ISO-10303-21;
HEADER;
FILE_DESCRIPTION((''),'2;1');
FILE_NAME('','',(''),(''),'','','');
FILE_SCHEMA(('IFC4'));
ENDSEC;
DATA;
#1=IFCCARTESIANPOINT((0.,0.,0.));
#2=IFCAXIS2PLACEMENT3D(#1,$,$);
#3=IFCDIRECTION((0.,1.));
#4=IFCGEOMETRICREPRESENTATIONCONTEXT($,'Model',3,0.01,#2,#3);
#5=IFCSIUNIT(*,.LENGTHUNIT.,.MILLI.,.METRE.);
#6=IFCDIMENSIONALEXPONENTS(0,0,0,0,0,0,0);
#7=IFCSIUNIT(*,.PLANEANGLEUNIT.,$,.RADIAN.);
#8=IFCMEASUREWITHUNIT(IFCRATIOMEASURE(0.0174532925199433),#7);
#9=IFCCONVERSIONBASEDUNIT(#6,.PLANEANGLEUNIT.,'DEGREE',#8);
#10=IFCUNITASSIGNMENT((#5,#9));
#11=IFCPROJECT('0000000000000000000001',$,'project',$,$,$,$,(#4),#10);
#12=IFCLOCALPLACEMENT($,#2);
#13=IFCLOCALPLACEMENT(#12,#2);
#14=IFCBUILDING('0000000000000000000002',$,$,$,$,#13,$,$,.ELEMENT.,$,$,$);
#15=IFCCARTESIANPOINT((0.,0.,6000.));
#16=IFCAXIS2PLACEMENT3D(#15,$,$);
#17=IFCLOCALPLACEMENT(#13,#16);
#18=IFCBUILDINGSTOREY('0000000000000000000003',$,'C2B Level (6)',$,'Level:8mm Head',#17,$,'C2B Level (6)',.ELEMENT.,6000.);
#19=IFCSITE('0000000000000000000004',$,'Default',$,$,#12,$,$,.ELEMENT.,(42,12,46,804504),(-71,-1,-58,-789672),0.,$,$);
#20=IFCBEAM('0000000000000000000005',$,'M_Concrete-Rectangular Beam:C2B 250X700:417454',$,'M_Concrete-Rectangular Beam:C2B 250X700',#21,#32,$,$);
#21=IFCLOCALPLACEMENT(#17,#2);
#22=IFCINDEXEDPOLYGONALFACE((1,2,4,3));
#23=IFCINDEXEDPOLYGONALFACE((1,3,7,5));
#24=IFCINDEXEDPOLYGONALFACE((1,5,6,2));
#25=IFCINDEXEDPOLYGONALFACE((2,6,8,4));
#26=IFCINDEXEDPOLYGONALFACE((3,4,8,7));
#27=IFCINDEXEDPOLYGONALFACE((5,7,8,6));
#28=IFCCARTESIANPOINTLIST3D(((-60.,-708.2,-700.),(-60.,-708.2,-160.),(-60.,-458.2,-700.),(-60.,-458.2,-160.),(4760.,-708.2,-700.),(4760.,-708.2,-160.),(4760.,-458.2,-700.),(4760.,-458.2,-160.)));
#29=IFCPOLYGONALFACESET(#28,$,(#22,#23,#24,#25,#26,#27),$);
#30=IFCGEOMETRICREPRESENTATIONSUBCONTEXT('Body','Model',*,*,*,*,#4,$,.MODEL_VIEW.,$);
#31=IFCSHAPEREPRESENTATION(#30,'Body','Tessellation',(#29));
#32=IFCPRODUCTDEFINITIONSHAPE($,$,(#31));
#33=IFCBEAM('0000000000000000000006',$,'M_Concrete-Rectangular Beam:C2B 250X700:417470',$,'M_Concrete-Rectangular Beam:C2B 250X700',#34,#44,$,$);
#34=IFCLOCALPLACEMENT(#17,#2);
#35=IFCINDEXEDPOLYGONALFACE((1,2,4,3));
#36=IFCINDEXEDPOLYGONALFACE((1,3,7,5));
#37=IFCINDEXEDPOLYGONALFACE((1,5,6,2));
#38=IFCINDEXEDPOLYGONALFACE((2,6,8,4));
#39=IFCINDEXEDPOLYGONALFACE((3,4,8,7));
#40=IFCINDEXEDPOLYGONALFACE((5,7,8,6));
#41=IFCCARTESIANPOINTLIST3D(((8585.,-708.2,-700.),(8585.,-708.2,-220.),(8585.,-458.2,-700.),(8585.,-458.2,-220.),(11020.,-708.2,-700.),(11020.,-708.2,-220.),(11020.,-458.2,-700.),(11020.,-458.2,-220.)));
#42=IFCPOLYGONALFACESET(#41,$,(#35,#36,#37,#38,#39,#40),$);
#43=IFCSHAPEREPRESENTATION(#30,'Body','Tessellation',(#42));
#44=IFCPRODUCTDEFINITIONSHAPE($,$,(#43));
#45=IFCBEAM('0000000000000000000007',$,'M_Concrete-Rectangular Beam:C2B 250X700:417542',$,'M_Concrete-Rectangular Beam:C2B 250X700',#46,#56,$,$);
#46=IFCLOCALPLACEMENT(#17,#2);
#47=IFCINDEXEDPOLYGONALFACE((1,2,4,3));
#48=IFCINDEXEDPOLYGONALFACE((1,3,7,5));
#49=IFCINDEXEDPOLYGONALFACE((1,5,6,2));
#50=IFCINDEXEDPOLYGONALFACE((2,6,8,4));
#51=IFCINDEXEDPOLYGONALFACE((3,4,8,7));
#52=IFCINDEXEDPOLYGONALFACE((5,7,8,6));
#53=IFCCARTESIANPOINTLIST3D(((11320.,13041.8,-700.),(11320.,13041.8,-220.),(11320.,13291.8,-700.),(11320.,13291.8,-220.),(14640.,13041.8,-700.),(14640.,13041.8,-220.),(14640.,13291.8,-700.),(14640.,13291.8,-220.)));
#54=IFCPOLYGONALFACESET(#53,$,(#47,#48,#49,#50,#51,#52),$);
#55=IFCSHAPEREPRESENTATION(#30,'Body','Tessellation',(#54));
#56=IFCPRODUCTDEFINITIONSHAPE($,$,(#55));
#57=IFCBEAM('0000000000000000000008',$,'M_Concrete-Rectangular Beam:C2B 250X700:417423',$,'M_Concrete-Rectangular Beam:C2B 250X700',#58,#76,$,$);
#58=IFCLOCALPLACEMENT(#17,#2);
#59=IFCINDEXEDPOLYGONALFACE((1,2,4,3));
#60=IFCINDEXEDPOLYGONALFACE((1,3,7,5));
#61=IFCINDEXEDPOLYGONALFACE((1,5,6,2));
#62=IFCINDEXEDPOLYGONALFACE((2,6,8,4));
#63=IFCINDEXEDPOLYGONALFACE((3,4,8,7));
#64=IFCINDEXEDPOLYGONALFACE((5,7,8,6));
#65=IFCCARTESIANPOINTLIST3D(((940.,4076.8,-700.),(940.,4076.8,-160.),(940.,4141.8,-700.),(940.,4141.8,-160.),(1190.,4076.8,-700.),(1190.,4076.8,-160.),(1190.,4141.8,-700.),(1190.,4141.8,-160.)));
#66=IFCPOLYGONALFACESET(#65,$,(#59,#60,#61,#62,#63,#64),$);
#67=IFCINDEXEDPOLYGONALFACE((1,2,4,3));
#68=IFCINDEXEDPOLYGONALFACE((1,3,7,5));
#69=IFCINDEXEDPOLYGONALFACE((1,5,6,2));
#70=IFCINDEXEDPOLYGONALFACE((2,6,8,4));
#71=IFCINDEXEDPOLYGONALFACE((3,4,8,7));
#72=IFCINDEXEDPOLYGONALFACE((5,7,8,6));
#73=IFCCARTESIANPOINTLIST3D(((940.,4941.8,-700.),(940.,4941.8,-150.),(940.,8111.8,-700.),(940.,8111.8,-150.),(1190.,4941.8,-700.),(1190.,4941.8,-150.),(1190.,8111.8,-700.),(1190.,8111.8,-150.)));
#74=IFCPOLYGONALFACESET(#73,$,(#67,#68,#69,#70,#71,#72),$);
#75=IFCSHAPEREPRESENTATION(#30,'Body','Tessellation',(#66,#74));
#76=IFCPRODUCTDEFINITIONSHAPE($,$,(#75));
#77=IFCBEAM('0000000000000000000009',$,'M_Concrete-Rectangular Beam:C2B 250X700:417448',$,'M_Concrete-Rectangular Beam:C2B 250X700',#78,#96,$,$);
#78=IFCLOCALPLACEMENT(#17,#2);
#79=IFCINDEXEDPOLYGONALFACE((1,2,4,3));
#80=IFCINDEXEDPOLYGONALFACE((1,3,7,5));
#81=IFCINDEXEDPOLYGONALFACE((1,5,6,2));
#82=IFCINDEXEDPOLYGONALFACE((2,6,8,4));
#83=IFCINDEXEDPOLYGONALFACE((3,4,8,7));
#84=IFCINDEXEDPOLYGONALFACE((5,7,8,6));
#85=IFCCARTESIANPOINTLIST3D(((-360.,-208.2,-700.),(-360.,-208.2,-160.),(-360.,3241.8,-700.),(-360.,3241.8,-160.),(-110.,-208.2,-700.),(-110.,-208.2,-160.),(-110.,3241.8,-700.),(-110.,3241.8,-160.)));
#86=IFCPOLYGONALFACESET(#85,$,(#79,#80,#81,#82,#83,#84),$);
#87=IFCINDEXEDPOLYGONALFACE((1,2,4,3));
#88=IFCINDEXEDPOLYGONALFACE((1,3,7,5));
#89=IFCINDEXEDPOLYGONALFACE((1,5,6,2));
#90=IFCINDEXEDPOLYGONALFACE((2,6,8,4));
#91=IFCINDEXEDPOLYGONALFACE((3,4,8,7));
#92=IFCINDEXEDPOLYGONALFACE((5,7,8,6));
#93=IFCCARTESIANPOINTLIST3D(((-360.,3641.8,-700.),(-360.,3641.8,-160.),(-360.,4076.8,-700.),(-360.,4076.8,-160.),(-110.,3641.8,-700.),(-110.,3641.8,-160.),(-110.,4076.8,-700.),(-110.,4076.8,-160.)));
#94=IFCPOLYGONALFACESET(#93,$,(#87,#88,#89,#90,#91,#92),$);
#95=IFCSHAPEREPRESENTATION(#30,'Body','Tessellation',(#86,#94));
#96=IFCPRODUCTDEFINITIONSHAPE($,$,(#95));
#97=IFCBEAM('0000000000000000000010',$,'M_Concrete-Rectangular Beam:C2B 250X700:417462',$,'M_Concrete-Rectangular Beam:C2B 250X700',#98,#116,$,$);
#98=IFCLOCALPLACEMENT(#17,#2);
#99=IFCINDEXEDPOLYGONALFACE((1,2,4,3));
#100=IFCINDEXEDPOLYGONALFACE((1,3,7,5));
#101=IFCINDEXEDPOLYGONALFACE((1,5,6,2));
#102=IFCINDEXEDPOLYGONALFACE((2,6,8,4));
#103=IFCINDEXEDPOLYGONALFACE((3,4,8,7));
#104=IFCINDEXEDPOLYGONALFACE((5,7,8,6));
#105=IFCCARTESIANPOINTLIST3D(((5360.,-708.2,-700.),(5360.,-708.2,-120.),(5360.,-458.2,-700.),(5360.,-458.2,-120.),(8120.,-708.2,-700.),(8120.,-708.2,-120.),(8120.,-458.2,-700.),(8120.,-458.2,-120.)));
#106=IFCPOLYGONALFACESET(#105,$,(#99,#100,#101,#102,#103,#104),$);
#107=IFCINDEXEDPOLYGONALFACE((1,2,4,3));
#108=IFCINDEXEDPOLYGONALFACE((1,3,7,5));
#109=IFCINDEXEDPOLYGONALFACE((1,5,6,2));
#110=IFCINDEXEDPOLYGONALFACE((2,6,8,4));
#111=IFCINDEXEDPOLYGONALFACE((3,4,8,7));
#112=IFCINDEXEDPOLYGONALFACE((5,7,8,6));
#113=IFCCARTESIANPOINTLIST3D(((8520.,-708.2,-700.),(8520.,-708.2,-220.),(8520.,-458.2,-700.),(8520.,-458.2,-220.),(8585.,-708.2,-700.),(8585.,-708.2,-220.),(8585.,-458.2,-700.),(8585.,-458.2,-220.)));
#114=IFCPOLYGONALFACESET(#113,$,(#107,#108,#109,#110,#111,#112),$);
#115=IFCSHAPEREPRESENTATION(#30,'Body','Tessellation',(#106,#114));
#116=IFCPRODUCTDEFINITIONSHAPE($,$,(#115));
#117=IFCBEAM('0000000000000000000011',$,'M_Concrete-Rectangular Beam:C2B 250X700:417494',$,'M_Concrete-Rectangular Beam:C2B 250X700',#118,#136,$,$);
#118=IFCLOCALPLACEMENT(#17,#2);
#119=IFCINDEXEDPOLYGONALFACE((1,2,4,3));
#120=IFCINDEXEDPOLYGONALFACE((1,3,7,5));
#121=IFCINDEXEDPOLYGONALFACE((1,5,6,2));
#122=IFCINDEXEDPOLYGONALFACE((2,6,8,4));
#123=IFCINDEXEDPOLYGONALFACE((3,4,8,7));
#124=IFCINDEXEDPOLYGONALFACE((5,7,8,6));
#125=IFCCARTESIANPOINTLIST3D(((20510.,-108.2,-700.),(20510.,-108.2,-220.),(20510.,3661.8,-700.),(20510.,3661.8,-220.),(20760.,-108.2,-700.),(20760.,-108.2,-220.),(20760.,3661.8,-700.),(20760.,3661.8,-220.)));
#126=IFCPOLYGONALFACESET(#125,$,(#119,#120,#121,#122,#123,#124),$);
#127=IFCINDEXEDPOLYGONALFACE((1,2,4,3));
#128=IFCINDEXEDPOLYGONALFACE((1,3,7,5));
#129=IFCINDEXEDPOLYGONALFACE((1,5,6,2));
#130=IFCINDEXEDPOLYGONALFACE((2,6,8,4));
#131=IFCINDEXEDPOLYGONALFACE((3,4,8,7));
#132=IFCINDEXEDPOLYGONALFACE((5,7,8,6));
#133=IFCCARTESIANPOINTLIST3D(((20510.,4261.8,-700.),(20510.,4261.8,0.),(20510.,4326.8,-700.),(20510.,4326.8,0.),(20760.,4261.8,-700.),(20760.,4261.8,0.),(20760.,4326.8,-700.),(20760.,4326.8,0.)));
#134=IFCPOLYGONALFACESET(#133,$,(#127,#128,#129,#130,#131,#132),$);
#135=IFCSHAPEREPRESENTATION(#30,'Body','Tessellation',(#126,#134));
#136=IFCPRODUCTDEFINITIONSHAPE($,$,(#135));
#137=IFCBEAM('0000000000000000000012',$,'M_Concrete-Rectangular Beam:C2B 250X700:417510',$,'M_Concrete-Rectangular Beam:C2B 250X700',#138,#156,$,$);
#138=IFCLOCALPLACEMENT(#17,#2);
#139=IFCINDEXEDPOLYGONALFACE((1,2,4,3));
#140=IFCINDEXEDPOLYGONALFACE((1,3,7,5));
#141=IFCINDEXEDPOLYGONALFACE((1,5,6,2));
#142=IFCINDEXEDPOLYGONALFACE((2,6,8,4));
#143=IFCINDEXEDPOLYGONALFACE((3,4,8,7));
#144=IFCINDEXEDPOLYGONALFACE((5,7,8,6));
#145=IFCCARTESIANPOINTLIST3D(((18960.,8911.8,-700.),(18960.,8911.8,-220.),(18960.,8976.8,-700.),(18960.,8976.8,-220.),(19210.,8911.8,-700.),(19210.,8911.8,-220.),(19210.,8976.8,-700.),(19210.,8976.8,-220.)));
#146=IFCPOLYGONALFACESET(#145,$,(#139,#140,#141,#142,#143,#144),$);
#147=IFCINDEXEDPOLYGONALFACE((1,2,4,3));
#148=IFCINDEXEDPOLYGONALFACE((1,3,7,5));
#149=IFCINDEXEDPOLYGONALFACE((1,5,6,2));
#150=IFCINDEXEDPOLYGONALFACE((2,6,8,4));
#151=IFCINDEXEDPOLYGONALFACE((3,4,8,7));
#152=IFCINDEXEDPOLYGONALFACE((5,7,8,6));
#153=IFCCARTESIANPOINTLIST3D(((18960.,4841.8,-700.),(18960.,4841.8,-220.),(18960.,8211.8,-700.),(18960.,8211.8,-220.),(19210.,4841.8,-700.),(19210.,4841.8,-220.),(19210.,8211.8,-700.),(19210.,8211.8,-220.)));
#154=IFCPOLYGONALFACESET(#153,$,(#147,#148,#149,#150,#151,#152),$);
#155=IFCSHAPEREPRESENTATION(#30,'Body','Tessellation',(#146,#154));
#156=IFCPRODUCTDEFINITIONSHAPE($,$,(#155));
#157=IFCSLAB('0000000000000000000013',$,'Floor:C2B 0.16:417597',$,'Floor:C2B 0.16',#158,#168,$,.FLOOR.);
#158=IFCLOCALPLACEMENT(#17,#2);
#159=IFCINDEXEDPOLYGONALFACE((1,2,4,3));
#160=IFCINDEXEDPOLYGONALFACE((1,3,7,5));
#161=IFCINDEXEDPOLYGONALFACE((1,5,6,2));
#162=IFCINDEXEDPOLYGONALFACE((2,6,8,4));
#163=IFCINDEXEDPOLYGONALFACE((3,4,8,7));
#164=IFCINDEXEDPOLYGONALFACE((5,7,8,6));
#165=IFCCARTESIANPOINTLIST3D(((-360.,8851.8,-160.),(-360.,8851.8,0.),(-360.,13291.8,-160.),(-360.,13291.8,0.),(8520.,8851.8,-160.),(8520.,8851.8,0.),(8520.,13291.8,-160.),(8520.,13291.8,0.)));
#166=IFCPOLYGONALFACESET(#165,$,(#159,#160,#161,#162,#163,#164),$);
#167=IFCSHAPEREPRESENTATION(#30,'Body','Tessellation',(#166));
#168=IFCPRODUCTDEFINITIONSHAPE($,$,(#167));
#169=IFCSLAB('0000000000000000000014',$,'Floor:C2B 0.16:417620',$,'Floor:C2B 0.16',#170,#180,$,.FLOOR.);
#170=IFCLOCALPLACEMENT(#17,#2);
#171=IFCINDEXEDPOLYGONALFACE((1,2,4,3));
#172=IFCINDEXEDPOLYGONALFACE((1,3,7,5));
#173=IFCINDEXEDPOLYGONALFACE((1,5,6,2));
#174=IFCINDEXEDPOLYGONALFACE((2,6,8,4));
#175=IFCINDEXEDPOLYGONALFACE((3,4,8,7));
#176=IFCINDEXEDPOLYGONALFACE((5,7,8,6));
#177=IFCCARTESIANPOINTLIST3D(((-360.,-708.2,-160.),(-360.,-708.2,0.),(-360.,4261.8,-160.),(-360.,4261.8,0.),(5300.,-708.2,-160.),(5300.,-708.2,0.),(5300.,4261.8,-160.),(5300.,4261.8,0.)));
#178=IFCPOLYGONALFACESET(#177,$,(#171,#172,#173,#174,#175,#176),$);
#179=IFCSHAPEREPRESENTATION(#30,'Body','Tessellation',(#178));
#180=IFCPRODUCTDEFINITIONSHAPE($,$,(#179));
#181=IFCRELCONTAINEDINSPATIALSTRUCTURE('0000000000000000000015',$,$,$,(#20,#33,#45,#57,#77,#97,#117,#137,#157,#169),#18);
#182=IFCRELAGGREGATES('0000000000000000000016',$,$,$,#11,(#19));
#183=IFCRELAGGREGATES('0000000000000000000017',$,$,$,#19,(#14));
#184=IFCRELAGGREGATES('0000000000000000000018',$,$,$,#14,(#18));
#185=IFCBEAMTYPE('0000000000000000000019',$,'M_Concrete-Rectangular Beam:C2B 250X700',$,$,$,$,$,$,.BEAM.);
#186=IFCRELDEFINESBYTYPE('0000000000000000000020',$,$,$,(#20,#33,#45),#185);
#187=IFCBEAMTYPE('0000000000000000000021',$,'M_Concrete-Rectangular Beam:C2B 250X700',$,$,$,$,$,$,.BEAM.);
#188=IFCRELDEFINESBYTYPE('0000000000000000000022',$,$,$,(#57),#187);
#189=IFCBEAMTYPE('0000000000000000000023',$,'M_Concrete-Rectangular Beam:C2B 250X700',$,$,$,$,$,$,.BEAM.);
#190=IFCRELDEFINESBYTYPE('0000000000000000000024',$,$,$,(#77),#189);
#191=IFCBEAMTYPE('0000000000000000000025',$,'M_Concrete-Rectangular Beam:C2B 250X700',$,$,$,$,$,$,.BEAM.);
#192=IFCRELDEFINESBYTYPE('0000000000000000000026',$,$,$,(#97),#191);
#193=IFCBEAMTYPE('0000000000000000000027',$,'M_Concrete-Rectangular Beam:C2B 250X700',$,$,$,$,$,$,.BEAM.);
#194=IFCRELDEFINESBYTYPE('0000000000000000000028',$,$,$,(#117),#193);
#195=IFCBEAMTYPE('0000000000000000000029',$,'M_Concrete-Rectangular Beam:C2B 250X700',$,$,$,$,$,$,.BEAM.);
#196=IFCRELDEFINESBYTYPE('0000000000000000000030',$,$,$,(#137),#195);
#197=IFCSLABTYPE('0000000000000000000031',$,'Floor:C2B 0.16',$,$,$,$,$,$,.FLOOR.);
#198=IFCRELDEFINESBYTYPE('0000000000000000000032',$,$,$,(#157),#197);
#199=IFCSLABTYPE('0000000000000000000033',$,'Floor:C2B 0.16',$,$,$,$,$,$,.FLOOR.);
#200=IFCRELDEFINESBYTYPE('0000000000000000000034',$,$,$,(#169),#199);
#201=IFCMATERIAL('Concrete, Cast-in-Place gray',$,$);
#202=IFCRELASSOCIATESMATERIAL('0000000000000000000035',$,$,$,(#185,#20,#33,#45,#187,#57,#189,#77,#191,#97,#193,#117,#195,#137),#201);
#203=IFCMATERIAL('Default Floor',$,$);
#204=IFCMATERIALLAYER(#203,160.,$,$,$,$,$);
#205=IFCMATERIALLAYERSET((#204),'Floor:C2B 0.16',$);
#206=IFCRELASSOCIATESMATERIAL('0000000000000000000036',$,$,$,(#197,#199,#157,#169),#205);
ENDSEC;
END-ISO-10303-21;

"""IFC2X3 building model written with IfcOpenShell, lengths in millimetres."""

from ifc_helpers import new_model, entity, si_unit, converted_unit, direction, frame, frame_2d, origin, place, context, subcontext, project, spatial, rectangle, extrude, source, transform, mapped, material, layer, layer_set, layer_usage, type_object, type_shapes, element, save


model = new_model("IFC2X3")

# Units and contexts
model_context = context("Model", 3, precision=0.01, world=origin(), true_north=direction((0.0, 1.0)))
body_context = subcontext(model_context, "Body", "Model", "MODEL_VIEW")
ifc_project = project(units=[si_unit("LENGTHUNIT", "METRE", prefix="MILLI"), converted_unit("PLANEANGLEUNIT", "DEGREE", entity("IfcRatioMeasure", 0.0174532925199433), si_unit("PLANEANGLEUNIT", "RADIAN"), dimensions=[0, 0, 0, 0, 0, 0, 0])], contexts=[model_context])

# Site, building, storey
site_placement = place(None, origin())
site = spatial("IfcSite", under=ifc_project, at=site_placement, Name="Default", CompositionType="ELEMENT", RefLatitude=(42, 12, 46, 804504), RefLongitude=(-71, -1, -58, -789672), RefElevation=0.0)
building_placement = place(site_placement, origin())
building = spatial("IfcBuilding", under=site, at=building_placement, CompositionType="ELEMENT")
storey_placement = place(building_placement, frame((0.0, 0.0, 6000.0)))
storey = spatial("IfcBuildingStorey", under=building, at=storey_placement, Name="C2B Level (6)", ObjectType="Level:8mm Head", LongName="C2B Level (6)", CompositionType="ELEMENT", Elevation=6000.0)

# Beams
ifc_material_1 = material(Name="Concrete, Cast-in-Place gray")
beam_type_1 = type_object("IfcBeamType", Name="M_Concrete-Rectangular Beam:C2B 250X700", PredefinedType="BEAM", material=ifc_material_1)
beam_1_placement = place(storey_placement, frame((4760.0, -583.2, 0.0), z_axis=(0.0, 0.0, 1.0), x_axis=(-1.0, 0.0, 0.0)))
element("IfcBeam", 1, at=beam_1_placement, inside=storey, type_object=beam_type_1, material=ifc_material_1, Name="M_Concrete-Rectangular Beam:C2B 250X700:417454", ObjectType="M_Concrete-Rectangular Beam:C2B 250X700", context=body_context, shape_type="SweptSolid", body=[
    extrude(rectangle(XDim=540.0, YDim=250.0, at=frame_2d((0.0, 0.0), x_axis=(1.0, 0.0))), frame((0.0, 0.0, -430.0), z_axis=(1.0, 0.0, 0.0), x_axis=(0.0, 0.0, -1.0)), (0.0, 0.0, 1.0), 4820.0),
])
beam_2_placement = place(storey_placement, frame((8460.0, -583.2, 0.0)))
element("IfcBeam", 2, at=beam_2_placement, inside=storey, type_object=beam_type_1, material=ifc_material_1, Name="M_Concrete-Rectangular Beam:C2B 250X700:417470", ObjectType="M_Concrete-Rectangular Beam:C2B 250X700", context=body_context, shape_type="SweptSolid", body=[
    extrude(rectangle(XDim=480.0, YDim=250.0, at=frame_2d((0.0, 0.0), x_axis=(1.0, 0.0))), frame((125.0, 0.0, -460.0), z_axis=(1.0, 0.0, 0.0), x_axis=(0.0, 0.0, -1.0)), (0.0, 0.0, 1.0), 2435.0),
])
beam_3_placement = place(storey_placement, frame((14640.0, 13166.8, 0.0), z_axis=(0.0, 0.0, 1.0), x_axis=(-1.0, 0.0, 0.0)))
element("IfcBeam", 3, at=beam_3_placement, inside=storey, type_object=beam_type_1, material=ifc_material_1, Name="M_Concrete-Rectangular Beam:C2B 250X700:417542", ObjectType="M_Concrete-Rectangular Beam:C2B 250X700", context=body_context, shape_type="SweptSolid", body=[
    extrude(rectangle(XDim=480.0, YDim=250.0, at=frame_2d((0.0, 0.0), x_axis=(1.0, 0.0))), frame((0.0, 0.0, -460.0), z_axis=(1.0, 0.0, 0.0), x_axis=(0.0, 0.0, -1.0)), (0.0, 0.0, 1.0), 3320.0),
])
beam_type_2 = type_object("IfcBeamType", Name="M_Concrete-Rectangular Beam:C2B 250X700", PredefinedType="BEAM", material=ifc_material_1)
shared_shape_1 = source(origin(), body_context, "Body", "SweptSolid", [
    extrude(rectangle(XDim=540.0, YDim=250.0, at=frame_2d((0.0, 0.0), x_axis=(0.0, 1.0))), frame((1065.0, 4141.8, 5570.0), z_axis=(0.0, -1.0, 0.0), x_axis=(-1.0, 0.0, 0.0)), (0.0, 0.0, 1.0), 65.0),
    extrude(rectangle(XDim=550.0, YDim=250.0, at=frame_2d((0.0, 0.0), x_axis=(0.0, 1.0))), frame((1065.0, 8111.8, 5575.0), z_axis=(0.0, -1.0, 0.0), x_axis=(-1.0, 0.0, 0.0)), (0.0, 0.0, 1.0), 3170.0),
])
type_shapes(beam_type_2, [shared_shape_1])
beam_4_placement = place(storey_placement, frame((0.0, 0.0, -6000.0)))
element("IfcBeam", 4, at=beam_4_placement, inside=storey, type_object=beam_type_2, material=ifc_material_1, Name="M_Concrete-Rectangular Beam:C2B 250X700:417423", ObjectType="M_Concrete-Rectangular Beam:C2B 250X700", context=body_context, shape_type="MappedRepresentation", body=[
    mapped(shared_shape_1, transform((0.0, 0.0, 0.0), scale=1.0)),
])
beam_type_3 = type_object("IfcBeamType", Name="M_Concrete-Rectangular Beam:C2B 250X700", PredefinedType="BEAM", material=ifc_material_1)
shared_shape_2 = source(origin(), body_context, "Body", "SweptSolid", [
    extrude(rectangle(XDim=540.0, YDim=250.0, at=frame_2d((0.0, 0.0), x_axis=(0.0, 1.0))), frame((-235.0, 3241.8, 5570.0), z_axis=(0.0, -1.0, 0.0), x_axis=(-1.0, 0.0, 0.0)), (0.0, 0.0, 1.0), 3450.0),
    extrude(rectangle(XDim=540.0, YDim=250.0, at=frame_2d((0.0, 0.0), x_axis=(0.0, 1.0))), frame((-235.0, 4076.8, 5570.0), z_axis=(0.0, -1.0, 0.0), x_axis=(-1.0, 0.0, 0.0)), (0.0, 0.0, 1.0), 435.0),
])
type_shapes(beam_type_3, [shared_shape_2])
beam_5_placement = place(storey_placement, frame((0.0, 0.0, -6000.0)))
element("IfcBeam", 5, at=beam_5_placement, inside=storey, type_object=beam_type_3, material=ifc_material_1, Name="M_Concrete-Rectangular Beam:C2B 250X700:417448", ObjectType="M_Concrete-Rectangular Beam:C2B 250X700", context=body_context, shape_type="MappedRepresentation", body=[
    mapped(shared_shape_2, transform((0.0, 0.0, 0.0), scale=1.0)),
])
beam_type_4 = type_object("IfcBeamType", Name="M_Concrete-Rectangular Beam:C2B 250X700", PredefinedType="BEAM", material=ifc_material_1)
shared_shape_3 = source(origin(), body_context, "Body", "SweptSolid", [
    extrude(rectangle(XDim=580.0, YDim=250.0, at=frame_2d((0.0, 0.0), x_axis=(1.0, 0.0))), frame((8120.0, -583.2, 5590.0), z_axis=(-1.0, 0.0, 0.0), x_axis=(0.0, 0.0, -1.0)), (0.0, 0.0, 1.0), 2760.0),
    extrude(rectangle(XDim=480.0, YDim=250.0, at=frame_2d((0.0, 0.0), x_axis=(1.0, 0.0))), frame((8585.0, -583.2, 5540.0), z_axis=(-1.0, 0.0, 0.0), x_axis=(0.0, 0.0, -1.0)), (0.0, 0.0, 1.0), 65.0),
])
type_shapes(beam_type_4, [shared_shape_3])
beam_6_placement = place(storey_placement, frame((0.0, 0.0, -6000.0)))
element("IfcBeam", 6, at=beam_6_placement, inside=storey, type_object=beam_type_4, material=ifc_material_1, Name="M_Concrete-Rectangular Beam:C2B 250X700:417462", ObjectType="M_Concrete-Rectangular Beam:C2B 250X700", context=body_context, shape_type="MappedRepresentation", body=[
    mapped(shared_shape_3, transform((0.0, 0.0, 0.0), scale=1.0)),
])
beam_type_5 = type_object("IfcBeamType", Name="M_Concrete-Rectangular Beam:C2B 250X700", PredefinedType="BEAM", material=ifc_material_1)
shared_shape_4 = source(origin(), body_context, "Body", "SweptSolid", [
    extrude(rectangle(XDim=480.0, YDim=250.0, at=frame_2d((0.0, 0.0), x_axis=(0.0, 1.0))), frame((20635.0, 3661.8, 5540.0), z_axis=(0.0, -1.0, 0.0), x_axis=(-1.0, 0.0, 0.0)), (0.0, 0.0, 1.0), 3770.0),
    extrude(rectangle(XDim=700.0, YDim=250.0, at=frame_2d((0.0, 0.0), x_axis=(0.0, 1.0))), frame((20635.0, 4326.8, 5650.0), z_axis=(0.0, -1.0, 0.0), x_axis=(-1.0, 0.0, 0.0)), (0.0, 0.0, 1.0), 65.0),
])
type_shapes(beam_type_5, [shared_shape_4])
beam_7_placement = place(storey_placement, frame((0.0, 0.0, -6000.0)))
element("IfcBeam", 7, at=beam_7_placement, inside=storey, type_object=beam_type_5, material=ifc_material_1, Name="M_Concrete-Rectangular Beam:C2B 250X700:417494", ObjectType="M_Concrete-Rectangular Beam:C2B 250X700", context=body_context, shape_type="MappedRepresentation", body=[
    mapped(shared_shape_4, transform((0.0, 0.0, 0.0), scale=1.0)),
])
beam_type_6 = type_object("IfcBeamType", Name="M_Concrete-Rectangular Beam:C2B 250X700", PredefinedType="BEAM", material=ifc_material_1)
shared_shape_5 = source(origin(), body_context, "Body", "SweptSolid", [
    extrude(rectangle(XDim=480.0, YDim=250.0, at=frame_2d((0.0, 0.0), x_axis=(0.0, 1.0))), frame((19085.0, 8911.8, 5540.0), z_axis=(0.0, 1.0, 0.0), x_axis=(-1.0, 0.0, 0.0)), (0.0, 0.0, 1.0), 65.0),
    extrude(rectangle(XDim=480.0, YDim=250.0, at=frame_2d((0.0, 0.0), x_axis=(0.0, 1.0))), frame((19085.0, 4841.8, 5540.0), z_axis=(0.0, 1.0, 0.0), x_axis=(-1.0, 0.0, 0.0)), (0.0, 0.0, 1.0), 3370.0),
])
type_shapes(beam_type_6, [shared_shape_5])
beam_8_placement = place(storey_placement, frame((0.0, 0.0, -6000.0)))
element("IfcBeam", 8, at=beam_8_placement, inside=storey, type_object=beam_type_6, material=ifc_material_1, Name="M_Concrete-Rectangular Beam:C2B 250X700:417510", ObjectType="M_Concrete-Rectangular Beam:C2B 250X700", context=body_context, shape_type="MappedRepresentation", body=[
    mapped(shared_shape_5, transform((0.0, 0.0, 0.0), scale=1.0)),
])

# Slabs
ifc_material_2 = material(Name="Default Floor")
ifc_layer_1 = layer(ifc_material_2, 160.0)
ifc_layer_set_1 = layer_set([ifc_layer_1], Name="Floor:C2B 0.16")
ifc_layer_usage_1 = layer_usage(ifc_layer_set_1, "AXIS3", "POSITIVE", 0.0)
slab_type_1 = type_object("IfcSlabType", Name="Floor:C2B 0.16", PredefinedType="FLOOR", material=ifc_layer_set_1)
slab_1_placement = place(storey_placement, origin())
element("IfcSlab", 9, at=slab_1_placement, inside=storey, type_object=slab_type_1, material=ifc_layer_usage_1, Name="Floor:C2B 0.16:417597", ObjectType="Floor:C2B 0.16", PredefinedType="FLOOR", context=body_context, shape_type="SweptSolid", body=[
    extrude(rectangle(XDim=4440.0, YDim=8880.0, at=frame_2d((0.0, 0.0), x_axis=(1.0, 0.0))), frame((4080.0, 11071.8, 0.0), z_axis=(0.0, 0.0, -1.0), x_axis=(0.0, 1.0, 0.0)), (0.0, 0.0, 1.0), 160.0),
])
ifc_layer_usage_2 = layer_usage(ifc_layer_set_1, "AXIS3", "POSITIVE", 0.0)
slab_type_2 = type_object("IfcSlabType", Name="Floor:C2B 0.16", PredefinedType="FLOOR", material=ifc_layer_set_1)
slab_2_placement = place(storey_placement, origin())
element("IfcSlab", 10, at=slab_2_placement, inside=storey, type_object=slab_type_2, material=ifc_layer_usage_2, Name="Floor:C2B 0.16:417620", ObjectType="Floor:C2B 0.16", PredefinedType="FLOOR", context=body_context, shape_type="SweptSolid", body=[
    extrude(rectangle(XDim=4970.0, YDim=5660.0, at=frame_2d((0.0, 0.0), x_axis=(1.0, 0.0))), frame((2470.0, 1776.8, 0.0), z_axis=(0.0, 0.0, -1.0), x_axis=(0.0, 1.0, 0.0)), (0.0, 0.0, 1.0), 160.0),
])

save(model, "model.ifc")
